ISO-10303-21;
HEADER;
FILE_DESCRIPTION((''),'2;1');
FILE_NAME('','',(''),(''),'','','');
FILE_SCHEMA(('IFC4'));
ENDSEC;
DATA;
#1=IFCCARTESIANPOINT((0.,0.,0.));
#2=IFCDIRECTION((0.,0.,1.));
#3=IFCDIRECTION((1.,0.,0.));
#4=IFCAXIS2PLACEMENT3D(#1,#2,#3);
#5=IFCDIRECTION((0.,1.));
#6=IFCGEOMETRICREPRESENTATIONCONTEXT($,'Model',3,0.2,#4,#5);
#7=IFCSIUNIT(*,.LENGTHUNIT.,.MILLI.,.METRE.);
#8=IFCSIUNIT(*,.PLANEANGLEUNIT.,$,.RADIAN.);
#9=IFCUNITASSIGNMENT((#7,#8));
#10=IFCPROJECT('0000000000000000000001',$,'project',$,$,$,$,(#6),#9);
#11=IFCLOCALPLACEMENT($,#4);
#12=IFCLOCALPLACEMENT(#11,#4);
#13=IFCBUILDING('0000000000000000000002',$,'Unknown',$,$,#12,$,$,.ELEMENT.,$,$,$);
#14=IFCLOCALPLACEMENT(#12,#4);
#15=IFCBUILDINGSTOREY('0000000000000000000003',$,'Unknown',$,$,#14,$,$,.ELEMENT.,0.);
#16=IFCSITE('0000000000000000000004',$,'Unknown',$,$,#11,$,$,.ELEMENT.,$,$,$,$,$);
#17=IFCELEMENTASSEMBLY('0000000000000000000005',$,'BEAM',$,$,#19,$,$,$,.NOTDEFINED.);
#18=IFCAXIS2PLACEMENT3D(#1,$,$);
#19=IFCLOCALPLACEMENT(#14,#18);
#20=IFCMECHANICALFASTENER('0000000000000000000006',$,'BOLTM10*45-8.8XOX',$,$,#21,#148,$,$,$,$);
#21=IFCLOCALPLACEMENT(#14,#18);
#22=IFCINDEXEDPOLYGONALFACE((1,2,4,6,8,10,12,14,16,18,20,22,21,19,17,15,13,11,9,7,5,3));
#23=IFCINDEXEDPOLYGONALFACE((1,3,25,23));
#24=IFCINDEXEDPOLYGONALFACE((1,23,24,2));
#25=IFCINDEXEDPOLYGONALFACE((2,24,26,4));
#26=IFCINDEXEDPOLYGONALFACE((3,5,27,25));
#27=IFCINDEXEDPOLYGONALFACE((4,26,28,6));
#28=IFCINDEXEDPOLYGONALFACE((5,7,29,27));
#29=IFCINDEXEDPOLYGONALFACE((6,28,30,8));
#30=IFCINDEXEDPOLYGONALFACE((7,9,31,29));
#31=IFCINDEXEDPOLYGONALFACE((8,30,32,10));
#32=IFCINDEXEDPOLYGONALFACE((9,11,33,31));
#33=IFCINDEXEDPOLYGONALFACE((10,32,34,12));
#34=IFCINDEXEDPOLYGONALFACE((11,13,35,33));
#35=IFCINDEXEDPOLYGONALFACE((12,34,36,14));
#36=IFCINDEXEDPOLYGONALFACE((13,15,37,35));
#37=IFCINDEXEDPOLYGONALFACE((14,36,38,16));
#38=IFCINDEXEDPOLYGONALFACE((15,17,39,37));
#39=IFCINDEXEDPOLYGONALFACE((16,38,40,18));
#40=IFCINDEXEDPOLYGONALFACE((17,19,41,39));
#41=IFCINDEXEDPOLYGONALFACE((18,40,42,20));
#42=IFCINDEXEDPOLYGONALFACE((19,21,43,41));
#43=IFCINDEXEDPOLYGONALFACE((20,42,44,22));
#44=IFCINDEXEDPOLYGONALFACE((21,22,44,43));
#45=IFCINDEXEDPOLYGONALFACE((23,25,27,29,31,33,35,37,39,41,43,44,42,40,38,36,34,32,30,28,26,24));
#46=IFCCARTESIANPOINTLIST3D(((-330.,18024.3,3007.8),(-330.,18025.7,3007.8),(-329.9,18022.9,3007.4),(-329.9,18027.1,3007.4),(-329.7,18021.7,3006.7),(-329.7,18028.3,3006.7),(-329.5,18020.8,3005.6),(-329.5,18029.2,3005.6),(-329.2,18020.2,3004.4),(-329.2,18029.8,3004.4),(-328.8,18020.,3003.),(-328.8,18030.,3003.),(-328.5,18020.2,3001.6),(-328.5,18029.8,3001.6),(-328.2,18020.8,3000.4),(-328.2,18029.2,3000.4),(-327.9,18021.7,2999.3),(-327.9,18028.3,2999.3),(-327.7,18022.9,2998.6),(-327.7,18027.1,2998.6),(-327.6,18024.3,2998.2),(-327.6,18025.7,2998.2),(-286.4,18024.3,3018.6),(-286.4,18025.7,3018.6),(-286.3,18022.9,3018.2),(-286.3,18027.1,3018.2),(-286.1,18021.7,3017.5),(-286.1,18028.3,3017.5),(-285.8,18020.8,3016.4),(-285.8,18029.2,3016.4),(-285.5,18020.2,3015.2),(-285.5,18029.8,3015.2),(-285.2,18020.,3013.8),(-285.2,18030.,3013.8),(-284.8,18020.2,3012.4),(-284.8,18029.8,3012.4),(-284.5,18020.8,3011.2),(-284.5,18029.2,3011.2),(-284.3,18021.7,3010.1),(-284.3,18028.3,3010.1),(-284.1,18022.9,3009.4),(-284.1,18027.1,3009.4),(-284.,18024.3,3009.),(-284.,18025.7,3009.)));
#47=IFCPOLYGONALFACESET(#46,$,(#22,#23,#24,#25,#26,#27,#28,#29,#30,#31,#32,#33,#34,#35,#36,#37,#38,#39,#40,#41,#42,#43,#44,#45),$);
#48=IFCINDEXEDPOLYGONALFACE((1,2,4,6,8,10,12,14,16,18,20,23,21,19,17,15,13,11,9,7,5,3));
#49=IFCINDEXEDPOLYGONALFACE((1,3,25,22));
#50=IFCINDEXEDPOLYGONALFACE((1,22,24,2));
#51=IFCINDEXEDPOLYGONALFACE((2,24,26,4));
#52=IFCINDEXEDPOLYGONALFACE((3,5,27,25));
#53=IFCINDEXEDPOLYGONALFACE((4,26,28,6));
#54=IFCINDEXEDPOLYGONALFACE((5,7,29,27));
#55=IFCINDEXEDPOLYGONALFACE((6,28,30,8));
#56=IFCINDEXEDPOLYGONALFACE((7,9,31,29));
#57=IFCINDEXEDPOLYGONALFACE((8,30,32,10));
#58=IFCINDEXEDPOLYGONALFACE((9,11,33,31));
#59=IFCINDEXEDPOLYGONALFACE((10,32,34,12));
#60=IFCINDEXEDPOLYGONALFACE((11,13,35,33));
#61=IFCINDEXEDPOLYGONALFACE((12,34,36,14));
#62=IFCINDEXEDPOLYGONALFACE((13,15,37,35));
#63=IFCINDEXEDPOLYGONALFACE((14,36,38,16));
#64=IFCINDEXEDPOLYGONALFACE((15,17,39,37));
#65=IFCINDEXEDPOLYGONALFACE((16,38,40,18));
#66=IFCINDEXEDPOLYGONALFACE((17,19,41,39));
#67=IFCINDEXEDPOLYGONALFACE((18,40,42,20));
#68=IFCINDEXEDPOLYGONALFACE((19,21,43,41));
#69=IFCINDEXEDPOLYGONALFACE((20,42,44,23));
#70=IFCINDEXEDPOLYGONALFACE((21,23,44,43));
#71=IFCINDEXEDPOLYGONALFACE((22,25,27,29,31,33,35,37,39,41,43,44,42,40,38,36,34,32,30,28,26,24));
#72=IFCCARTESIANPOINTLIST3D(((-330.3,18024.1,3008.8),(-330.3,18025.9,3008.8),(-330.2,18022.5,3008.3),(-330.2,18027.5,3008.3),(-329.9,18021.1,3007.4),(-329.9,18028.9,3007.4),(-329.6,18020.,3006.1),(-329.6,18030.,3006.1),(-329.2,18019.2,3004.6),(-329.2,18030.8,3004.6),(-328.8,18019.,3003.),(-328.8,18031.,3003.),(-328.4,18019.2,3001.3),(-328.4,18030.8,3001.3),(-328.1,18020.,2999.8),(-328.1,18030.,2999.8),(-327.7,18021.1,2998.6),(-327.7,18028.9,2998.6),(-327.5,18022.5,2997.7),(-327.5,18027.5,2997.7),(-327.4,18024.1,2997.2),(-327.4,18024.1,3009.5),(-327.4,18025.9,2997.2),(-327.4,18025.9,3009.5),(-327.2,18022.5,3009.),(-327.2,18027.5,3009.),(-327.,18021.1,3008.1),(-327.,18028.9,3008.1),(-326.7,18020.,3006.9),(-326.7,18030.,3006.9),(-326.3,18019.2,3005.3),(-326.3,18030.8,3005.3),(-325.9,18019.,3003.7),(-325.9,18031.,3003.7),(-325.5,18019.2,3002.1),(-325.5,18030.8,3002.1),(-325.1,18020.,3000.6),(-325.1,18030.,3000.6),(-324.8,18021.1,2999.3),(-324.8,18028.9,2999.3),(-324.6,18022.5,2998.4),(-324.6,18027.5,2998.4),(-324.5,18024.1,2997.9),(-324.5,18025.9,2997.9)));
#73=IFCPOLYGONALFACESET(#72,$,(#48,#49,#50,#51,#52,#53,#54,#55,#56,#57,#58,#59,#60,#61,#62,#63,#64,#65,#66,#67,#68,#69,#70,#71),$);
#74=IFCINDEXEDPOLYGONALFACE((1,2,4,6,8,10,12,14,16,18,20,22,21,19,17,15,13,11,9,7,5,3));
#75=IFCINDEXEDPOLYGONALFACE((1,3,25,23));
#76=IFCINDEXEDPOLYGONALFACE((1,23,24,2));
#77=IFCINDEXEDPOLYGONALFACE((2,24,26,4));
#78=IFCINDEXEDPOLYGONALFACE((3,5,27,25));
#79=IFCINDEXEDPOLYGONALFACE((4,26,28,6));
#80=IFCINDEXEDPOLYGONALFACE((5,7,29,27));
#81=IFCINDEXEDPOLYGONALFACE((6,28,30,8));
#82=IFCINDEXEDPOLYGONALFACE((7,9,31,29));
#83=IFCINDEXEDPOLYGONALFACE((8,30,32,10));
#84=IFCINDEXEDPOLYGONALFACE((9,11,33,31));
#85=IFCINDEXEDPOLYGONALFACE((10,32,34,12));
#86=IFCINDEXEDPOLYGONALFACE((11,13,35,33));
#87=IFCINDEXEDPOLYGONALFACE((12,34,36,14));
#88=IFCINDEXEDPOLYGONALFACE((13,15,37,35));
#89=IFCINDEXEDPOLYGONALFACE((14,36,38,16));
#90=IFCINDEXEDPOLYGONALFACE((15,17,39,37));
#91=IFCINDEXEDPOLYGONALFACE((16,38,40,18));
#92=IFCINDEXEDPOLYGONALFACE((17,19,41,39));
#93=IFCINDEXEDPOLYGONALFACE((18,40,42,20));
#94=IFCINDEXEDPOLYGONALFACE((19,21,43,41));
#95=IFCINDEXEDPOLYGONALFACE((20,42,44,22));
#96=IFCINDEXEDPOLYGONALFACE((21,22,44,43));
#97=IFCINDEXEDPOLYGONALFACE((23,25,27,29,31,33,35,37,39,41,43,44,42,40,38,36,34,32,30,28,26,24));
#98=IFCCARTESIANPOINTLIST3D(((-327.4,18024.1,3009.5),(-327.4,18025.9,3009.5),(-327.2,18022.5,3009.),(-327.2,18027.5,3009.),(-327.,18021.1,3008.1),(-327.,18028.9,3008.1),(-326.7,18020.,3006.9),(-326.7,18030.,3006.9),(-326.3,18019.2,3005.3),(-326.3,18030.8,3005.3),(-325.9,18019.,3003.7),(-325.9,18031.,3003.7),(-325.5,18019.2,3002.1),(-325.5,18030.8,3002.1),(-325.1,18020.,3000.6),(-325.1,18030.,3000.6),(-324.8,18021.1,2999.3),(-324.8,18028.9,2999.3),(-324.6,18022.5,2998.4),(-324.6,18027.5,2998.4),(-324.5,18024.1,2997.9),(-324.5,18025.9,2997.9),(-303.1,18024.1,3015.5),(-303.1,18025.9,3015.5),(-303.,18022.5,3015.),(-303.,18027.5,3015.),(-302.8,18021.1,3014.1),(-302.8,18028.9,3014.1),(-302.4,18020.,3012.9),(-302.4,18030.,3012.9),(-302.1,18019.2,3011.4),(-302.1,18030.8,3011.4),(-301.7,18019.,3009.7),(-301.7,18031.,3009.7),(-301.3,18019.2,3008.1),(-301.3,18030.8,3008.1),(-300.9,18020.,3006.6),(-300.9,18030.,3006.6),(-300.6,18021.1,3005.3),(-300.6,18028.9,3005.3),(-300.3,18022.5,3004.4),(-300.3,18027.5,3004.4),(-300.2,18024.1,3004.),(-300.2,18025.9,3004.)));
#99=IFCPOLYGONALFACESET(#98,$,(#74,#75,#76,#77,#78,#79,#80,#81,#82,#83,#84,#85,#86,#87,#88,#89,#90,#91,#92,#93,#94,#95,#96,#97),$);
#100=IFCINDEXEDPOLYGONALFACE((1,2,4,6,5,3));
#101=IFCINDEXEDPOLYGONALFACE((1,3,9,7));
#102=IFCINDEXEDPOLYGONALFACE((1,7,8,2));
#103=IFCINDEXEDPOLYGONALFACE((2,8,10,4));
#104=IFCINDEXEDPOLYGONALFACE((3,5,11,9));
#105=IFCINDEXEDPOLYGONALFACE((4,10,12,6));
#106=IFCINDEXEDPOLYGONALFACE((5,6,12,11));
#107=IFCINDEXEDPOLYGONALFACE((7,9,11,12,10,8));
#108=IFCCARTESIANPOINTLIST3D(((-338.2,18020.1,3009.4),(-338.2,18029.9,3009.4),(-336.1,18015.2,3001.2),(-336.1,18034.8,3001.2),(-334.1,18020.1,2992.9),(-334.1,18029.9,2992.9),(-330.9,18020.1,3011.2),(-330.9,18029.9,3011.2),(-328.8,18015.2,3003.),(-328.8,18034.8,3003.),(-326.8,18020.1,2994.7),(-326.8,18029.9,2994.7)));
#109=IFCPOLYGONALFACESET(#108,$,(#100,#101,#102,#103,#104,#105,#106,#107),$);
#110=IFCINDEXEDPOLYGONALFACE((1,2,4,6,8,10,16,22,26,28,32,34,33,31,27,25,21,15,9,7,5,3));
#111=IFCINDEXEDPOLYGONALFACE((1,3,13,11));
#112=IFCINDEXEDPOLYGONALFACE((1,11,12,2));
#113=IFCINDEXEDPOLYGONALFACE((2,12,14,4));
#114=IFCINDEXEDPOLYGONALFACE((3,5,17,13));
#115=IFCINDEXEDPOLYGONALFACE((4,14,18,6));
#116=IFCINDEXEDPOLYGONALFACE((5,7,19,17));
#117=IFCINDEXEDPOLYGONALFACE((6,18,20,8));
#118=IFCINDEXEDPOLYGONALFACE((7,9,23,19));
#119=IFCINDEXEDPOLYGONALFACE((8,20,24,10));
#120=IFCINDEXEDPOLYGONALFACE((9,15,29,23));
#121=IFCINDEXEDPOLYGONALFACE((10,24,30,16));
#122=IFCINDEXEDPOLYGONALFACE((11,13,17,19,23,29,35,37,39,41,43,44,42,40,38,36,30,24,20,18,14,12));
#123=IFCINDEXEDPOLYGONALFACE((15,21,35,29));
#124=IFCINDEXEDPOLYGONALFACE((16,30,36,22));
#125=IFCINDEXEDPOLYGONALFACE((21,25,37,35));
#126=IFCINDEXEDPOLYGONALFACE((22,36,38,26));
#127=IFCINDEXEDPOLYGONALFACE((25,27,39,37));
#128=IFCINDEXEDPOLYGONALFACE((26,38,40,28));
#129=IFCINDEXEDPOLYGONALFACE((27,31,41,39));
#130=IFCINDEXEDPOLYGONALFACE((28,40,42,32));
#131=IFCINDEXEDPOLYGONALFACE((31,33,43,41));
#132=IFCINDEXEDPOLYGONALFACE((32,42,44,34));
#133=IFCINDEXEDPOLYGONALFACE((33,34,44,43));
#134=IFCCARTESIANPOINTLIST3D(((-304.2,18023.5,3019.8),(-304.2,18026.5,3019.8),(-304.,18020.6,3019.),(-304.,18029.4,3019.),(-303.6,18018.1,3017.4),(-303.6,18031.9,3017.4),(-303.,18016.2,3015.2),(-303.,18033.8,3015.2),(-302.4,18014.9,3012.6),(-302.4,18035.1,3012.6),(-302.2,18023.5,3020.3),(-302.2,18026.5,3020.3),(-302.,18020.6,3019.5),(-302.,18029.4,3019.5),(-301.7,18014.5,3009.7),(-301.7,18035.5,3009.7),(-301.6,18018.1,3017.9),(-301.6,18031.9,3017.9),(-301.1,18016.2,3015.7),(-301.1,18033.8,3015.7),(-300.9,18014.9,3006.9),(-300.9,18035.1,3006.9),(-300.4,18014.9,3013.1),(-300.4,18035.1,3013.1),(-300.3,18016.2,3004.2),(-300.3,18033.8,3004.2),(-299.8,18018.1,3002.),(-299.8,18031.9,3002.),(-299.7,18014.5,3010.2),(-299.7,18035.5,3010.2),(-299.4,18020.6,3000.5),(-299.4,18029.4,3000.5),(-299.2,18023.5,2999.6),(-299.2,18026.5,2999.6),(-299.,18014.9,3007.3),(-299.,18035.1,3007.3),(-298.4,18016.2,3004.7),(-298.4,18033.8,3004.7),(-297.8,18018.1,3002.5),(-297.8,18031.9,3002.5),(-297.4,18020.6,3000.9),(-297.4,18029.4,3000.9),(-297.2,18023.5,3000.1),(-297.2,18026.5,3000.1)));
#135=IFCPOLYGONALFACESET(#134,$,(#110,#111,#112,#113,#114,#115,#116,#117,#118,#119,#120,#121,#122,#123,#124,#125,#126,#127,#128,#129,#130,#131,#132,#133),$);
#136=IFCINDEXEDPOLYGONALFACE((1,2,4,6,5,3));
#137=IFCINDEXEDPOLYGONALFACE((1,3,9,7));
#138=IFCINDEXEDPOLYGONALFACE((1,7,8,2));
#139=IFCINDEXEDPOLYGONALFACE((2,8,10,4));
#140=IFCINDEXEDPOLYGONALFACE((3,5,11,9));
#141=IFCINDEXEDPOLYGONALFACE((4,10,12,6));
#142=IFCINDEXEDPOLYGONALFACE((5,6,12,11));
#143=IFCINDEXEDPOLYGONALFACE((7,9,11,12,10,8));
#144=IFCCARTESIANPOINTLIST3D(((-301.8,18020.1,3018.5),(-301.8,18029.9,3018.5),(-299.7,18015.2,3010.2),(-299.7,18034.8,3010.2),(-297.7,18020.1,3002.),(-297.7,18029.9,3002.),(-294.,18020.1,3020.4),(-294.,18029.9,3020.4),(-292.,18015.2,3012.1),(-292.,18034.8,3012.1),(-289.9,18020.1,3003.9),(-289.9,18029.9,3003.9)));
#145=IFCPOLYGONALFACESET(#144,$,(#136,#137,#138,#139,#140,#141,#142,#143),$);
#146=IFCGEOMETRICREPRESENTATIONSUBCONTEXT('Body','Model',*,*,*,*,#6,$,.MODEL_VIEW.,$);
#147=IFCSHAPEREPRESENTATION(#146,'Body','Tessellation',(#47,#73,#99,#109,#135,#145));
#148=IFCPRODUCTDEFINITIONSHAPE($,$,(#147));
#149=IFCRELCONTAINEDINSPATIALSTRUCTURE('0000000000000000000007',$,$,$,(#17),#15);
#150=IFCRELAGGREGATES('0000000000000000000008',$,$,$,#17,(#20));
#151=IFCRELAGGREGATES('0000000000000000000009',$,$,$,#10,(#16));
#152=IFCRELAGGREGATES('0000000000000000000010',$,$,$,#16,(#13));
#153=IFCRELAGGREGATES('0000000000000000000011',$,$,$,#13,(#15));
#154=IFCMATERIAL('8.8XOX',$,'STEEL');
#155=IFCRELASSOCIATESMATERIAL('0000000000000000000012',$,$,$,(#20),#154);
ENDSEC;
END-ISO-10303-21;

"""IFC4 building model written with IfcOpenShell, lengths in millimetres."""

from ifc_helpers import new_model, si_unit, direction, frame, origin_with_axes, place, context, subcontext, project, spatial, line, arc, indexed_curve, outline, extrude, source, transform, mapped, material, element, aggregate, save


model = new_model("IFC4")

# Units and contexts
model_context = context("Model", 3, precision=0.2, world=origin_with_axes(), true_north=direction((0.0, 1.0)))
body_context = subcontext(model_context, "Body", "Model", "MODEL_VIEW")
ifc_project = project(units=[si_unit("LENGTHUNIT", "METRE", prefix="MILLI"), si_unit("PLANEANGLEUNIT", "RADIAN")], contexts=[model_context])

# Site, building, storey
site_placement = place(None, origin_with_axes())
site = spatial("IfcSite", under=ifc_project, at=site_placement, Name="Unknown", CompositionType="ELEMENT")
building_placement = place(site_placement, origin_with_axes())
building = spatial("IfcBuilding", under=site, at=building_placement, Name="Unknown", CompositionType="ELEMENT")
storey_placement = place(building_placement, origin_with_axes())
storey = spatial("IfcBuildingStorey", under=building, at=storey_placement, Name="Unknown", CompositionType="ELEMENT", Elevation=0.0)

# Element assembly, mechanical fastener
ifc_material_1 = material(Name="8.8XOX", Category="STEEL")
shared_shape_1 = source(origin_with_axes(), body_context, "Body", "SweptSolid", [
    extrude(outline(indexed_curve([(5.0, 0.0), (0.0, 5.0), (-5.0, 0.0), (0.0, -5.0)], segments=[arc(1, 2, 3), arc(3, 4, 1)])), frame((0.0, 0.0, 3.8), z_axis=(0.0, 0.0, -1.0), x_axis=(0.0, 1.0, 0.0)), (0.0, 0.0, 1.0), 45.0),
    extrude(outline(indexed_curve([(6.0, 0.0), (0.0, 6.0), (-6.0, 0.0), (0.0, -6.0)], segments=[arc(1, 2, 3), arc(3, 4, 1)])), frame((0.0, 0.0, 3.8), z_axis=(0.0, 0.0, -1.0), x_axis=(0.0, 1.0, 0.0)), (0.0, 0.0, 1.0), 3.0),
    extrude(outline(indexed_curve([(6.0, 0.0), (0.0, 6.0), (-6.0, 0.0), (0.0, -6.0)], segments=[arc(1, 2, 3), arc(3, 4, 1)])), frame((0.0, 0.0, 0.8), z_axis=(0.0, 0.0, -1.0), x_axis=(0.0, 1.0, 0.0)), (0.0, 0.0, 1.0), 25.0),
    extrude(outline(indexed_curve([(9.8, 0.0), (4.9, 8.5), (-4.9, 8.5), (-9.8, 0.0), (-4.9, -8.5), (4.9, -8.5)], segments=[line(1, 2, 3, 4, 5, 6, 1)])), frame((0.0, 0.0, 11.2), z_axis=(0.0, 0.0, -1.0), x_axis=(0.0, 1.0, 0.0)), (0.0, 0.0, 1.0), 7.5),
    extrude(outline(indexed_curve([(10.5, 0.0), (0.0, 10.5), (-10.5, 0.0), (0.0, -10.5)], segments=[arc(1, 2, 3), arc(3, 4, 1)])), frame((0.0, 0.0, -24.2), z_axis=(0.0, 0.0, -1.0), x_axis=(0.0, 1.0, 0.0)), (0.0, 0.0, 1.0), 2.0),
    extrude(outline(indexed_curve([(9.8, 0.0), (4.9, 8.5), (-4.9, 8.5), (-9.8, 0.0), (-4.9, -8.5), (4.9, -8.5)], segments=[line(1, 2, 3, 4, 5, 6, 1)])), frame((0.0, 0.0, -26.2), z_axis=(0.0, 0.0, -1.0), x_axis=(0.0, 1.0, 0.0)), (0.0, 0.0, 1.0), 8.0),
])
assembly_1_placement = place(storey_placement, frame((-315.0, 18000.0, 3011.6), z_axis=(0.970613, 0.0, 0.240648), x_axis=(0.0, 1.0, 0.0)))
assembly_1 = element("IfcElementAssembly", 1, at=assembly_1_placement, inside=storey, Name="BEAM", PredefinedType="NOTDEFINED")
mechanical_fastener_1_placement = place(assembly_1_placement, frame((25.0, -5.0, -11.8), z_axis=(0.0, 0.0, -1.0), x_axis=(0.0, 1.0, 0.0)))
mechanical_fastener_1 = element("IfcMechanicalFastener", 2, at=mechanical_fastener_1_placement, material=ifc_material_1, Name="BOLTM10*45-8.8XOX", context=body_context, shape_type="MappedRepresentation", body=[
    mapped(shared_shape_1, transform((0.0, 0.0, 0.0))),
])
aggregate(assembly_1, [mechanical_fastener_1])

save(model, "model.ifc")
